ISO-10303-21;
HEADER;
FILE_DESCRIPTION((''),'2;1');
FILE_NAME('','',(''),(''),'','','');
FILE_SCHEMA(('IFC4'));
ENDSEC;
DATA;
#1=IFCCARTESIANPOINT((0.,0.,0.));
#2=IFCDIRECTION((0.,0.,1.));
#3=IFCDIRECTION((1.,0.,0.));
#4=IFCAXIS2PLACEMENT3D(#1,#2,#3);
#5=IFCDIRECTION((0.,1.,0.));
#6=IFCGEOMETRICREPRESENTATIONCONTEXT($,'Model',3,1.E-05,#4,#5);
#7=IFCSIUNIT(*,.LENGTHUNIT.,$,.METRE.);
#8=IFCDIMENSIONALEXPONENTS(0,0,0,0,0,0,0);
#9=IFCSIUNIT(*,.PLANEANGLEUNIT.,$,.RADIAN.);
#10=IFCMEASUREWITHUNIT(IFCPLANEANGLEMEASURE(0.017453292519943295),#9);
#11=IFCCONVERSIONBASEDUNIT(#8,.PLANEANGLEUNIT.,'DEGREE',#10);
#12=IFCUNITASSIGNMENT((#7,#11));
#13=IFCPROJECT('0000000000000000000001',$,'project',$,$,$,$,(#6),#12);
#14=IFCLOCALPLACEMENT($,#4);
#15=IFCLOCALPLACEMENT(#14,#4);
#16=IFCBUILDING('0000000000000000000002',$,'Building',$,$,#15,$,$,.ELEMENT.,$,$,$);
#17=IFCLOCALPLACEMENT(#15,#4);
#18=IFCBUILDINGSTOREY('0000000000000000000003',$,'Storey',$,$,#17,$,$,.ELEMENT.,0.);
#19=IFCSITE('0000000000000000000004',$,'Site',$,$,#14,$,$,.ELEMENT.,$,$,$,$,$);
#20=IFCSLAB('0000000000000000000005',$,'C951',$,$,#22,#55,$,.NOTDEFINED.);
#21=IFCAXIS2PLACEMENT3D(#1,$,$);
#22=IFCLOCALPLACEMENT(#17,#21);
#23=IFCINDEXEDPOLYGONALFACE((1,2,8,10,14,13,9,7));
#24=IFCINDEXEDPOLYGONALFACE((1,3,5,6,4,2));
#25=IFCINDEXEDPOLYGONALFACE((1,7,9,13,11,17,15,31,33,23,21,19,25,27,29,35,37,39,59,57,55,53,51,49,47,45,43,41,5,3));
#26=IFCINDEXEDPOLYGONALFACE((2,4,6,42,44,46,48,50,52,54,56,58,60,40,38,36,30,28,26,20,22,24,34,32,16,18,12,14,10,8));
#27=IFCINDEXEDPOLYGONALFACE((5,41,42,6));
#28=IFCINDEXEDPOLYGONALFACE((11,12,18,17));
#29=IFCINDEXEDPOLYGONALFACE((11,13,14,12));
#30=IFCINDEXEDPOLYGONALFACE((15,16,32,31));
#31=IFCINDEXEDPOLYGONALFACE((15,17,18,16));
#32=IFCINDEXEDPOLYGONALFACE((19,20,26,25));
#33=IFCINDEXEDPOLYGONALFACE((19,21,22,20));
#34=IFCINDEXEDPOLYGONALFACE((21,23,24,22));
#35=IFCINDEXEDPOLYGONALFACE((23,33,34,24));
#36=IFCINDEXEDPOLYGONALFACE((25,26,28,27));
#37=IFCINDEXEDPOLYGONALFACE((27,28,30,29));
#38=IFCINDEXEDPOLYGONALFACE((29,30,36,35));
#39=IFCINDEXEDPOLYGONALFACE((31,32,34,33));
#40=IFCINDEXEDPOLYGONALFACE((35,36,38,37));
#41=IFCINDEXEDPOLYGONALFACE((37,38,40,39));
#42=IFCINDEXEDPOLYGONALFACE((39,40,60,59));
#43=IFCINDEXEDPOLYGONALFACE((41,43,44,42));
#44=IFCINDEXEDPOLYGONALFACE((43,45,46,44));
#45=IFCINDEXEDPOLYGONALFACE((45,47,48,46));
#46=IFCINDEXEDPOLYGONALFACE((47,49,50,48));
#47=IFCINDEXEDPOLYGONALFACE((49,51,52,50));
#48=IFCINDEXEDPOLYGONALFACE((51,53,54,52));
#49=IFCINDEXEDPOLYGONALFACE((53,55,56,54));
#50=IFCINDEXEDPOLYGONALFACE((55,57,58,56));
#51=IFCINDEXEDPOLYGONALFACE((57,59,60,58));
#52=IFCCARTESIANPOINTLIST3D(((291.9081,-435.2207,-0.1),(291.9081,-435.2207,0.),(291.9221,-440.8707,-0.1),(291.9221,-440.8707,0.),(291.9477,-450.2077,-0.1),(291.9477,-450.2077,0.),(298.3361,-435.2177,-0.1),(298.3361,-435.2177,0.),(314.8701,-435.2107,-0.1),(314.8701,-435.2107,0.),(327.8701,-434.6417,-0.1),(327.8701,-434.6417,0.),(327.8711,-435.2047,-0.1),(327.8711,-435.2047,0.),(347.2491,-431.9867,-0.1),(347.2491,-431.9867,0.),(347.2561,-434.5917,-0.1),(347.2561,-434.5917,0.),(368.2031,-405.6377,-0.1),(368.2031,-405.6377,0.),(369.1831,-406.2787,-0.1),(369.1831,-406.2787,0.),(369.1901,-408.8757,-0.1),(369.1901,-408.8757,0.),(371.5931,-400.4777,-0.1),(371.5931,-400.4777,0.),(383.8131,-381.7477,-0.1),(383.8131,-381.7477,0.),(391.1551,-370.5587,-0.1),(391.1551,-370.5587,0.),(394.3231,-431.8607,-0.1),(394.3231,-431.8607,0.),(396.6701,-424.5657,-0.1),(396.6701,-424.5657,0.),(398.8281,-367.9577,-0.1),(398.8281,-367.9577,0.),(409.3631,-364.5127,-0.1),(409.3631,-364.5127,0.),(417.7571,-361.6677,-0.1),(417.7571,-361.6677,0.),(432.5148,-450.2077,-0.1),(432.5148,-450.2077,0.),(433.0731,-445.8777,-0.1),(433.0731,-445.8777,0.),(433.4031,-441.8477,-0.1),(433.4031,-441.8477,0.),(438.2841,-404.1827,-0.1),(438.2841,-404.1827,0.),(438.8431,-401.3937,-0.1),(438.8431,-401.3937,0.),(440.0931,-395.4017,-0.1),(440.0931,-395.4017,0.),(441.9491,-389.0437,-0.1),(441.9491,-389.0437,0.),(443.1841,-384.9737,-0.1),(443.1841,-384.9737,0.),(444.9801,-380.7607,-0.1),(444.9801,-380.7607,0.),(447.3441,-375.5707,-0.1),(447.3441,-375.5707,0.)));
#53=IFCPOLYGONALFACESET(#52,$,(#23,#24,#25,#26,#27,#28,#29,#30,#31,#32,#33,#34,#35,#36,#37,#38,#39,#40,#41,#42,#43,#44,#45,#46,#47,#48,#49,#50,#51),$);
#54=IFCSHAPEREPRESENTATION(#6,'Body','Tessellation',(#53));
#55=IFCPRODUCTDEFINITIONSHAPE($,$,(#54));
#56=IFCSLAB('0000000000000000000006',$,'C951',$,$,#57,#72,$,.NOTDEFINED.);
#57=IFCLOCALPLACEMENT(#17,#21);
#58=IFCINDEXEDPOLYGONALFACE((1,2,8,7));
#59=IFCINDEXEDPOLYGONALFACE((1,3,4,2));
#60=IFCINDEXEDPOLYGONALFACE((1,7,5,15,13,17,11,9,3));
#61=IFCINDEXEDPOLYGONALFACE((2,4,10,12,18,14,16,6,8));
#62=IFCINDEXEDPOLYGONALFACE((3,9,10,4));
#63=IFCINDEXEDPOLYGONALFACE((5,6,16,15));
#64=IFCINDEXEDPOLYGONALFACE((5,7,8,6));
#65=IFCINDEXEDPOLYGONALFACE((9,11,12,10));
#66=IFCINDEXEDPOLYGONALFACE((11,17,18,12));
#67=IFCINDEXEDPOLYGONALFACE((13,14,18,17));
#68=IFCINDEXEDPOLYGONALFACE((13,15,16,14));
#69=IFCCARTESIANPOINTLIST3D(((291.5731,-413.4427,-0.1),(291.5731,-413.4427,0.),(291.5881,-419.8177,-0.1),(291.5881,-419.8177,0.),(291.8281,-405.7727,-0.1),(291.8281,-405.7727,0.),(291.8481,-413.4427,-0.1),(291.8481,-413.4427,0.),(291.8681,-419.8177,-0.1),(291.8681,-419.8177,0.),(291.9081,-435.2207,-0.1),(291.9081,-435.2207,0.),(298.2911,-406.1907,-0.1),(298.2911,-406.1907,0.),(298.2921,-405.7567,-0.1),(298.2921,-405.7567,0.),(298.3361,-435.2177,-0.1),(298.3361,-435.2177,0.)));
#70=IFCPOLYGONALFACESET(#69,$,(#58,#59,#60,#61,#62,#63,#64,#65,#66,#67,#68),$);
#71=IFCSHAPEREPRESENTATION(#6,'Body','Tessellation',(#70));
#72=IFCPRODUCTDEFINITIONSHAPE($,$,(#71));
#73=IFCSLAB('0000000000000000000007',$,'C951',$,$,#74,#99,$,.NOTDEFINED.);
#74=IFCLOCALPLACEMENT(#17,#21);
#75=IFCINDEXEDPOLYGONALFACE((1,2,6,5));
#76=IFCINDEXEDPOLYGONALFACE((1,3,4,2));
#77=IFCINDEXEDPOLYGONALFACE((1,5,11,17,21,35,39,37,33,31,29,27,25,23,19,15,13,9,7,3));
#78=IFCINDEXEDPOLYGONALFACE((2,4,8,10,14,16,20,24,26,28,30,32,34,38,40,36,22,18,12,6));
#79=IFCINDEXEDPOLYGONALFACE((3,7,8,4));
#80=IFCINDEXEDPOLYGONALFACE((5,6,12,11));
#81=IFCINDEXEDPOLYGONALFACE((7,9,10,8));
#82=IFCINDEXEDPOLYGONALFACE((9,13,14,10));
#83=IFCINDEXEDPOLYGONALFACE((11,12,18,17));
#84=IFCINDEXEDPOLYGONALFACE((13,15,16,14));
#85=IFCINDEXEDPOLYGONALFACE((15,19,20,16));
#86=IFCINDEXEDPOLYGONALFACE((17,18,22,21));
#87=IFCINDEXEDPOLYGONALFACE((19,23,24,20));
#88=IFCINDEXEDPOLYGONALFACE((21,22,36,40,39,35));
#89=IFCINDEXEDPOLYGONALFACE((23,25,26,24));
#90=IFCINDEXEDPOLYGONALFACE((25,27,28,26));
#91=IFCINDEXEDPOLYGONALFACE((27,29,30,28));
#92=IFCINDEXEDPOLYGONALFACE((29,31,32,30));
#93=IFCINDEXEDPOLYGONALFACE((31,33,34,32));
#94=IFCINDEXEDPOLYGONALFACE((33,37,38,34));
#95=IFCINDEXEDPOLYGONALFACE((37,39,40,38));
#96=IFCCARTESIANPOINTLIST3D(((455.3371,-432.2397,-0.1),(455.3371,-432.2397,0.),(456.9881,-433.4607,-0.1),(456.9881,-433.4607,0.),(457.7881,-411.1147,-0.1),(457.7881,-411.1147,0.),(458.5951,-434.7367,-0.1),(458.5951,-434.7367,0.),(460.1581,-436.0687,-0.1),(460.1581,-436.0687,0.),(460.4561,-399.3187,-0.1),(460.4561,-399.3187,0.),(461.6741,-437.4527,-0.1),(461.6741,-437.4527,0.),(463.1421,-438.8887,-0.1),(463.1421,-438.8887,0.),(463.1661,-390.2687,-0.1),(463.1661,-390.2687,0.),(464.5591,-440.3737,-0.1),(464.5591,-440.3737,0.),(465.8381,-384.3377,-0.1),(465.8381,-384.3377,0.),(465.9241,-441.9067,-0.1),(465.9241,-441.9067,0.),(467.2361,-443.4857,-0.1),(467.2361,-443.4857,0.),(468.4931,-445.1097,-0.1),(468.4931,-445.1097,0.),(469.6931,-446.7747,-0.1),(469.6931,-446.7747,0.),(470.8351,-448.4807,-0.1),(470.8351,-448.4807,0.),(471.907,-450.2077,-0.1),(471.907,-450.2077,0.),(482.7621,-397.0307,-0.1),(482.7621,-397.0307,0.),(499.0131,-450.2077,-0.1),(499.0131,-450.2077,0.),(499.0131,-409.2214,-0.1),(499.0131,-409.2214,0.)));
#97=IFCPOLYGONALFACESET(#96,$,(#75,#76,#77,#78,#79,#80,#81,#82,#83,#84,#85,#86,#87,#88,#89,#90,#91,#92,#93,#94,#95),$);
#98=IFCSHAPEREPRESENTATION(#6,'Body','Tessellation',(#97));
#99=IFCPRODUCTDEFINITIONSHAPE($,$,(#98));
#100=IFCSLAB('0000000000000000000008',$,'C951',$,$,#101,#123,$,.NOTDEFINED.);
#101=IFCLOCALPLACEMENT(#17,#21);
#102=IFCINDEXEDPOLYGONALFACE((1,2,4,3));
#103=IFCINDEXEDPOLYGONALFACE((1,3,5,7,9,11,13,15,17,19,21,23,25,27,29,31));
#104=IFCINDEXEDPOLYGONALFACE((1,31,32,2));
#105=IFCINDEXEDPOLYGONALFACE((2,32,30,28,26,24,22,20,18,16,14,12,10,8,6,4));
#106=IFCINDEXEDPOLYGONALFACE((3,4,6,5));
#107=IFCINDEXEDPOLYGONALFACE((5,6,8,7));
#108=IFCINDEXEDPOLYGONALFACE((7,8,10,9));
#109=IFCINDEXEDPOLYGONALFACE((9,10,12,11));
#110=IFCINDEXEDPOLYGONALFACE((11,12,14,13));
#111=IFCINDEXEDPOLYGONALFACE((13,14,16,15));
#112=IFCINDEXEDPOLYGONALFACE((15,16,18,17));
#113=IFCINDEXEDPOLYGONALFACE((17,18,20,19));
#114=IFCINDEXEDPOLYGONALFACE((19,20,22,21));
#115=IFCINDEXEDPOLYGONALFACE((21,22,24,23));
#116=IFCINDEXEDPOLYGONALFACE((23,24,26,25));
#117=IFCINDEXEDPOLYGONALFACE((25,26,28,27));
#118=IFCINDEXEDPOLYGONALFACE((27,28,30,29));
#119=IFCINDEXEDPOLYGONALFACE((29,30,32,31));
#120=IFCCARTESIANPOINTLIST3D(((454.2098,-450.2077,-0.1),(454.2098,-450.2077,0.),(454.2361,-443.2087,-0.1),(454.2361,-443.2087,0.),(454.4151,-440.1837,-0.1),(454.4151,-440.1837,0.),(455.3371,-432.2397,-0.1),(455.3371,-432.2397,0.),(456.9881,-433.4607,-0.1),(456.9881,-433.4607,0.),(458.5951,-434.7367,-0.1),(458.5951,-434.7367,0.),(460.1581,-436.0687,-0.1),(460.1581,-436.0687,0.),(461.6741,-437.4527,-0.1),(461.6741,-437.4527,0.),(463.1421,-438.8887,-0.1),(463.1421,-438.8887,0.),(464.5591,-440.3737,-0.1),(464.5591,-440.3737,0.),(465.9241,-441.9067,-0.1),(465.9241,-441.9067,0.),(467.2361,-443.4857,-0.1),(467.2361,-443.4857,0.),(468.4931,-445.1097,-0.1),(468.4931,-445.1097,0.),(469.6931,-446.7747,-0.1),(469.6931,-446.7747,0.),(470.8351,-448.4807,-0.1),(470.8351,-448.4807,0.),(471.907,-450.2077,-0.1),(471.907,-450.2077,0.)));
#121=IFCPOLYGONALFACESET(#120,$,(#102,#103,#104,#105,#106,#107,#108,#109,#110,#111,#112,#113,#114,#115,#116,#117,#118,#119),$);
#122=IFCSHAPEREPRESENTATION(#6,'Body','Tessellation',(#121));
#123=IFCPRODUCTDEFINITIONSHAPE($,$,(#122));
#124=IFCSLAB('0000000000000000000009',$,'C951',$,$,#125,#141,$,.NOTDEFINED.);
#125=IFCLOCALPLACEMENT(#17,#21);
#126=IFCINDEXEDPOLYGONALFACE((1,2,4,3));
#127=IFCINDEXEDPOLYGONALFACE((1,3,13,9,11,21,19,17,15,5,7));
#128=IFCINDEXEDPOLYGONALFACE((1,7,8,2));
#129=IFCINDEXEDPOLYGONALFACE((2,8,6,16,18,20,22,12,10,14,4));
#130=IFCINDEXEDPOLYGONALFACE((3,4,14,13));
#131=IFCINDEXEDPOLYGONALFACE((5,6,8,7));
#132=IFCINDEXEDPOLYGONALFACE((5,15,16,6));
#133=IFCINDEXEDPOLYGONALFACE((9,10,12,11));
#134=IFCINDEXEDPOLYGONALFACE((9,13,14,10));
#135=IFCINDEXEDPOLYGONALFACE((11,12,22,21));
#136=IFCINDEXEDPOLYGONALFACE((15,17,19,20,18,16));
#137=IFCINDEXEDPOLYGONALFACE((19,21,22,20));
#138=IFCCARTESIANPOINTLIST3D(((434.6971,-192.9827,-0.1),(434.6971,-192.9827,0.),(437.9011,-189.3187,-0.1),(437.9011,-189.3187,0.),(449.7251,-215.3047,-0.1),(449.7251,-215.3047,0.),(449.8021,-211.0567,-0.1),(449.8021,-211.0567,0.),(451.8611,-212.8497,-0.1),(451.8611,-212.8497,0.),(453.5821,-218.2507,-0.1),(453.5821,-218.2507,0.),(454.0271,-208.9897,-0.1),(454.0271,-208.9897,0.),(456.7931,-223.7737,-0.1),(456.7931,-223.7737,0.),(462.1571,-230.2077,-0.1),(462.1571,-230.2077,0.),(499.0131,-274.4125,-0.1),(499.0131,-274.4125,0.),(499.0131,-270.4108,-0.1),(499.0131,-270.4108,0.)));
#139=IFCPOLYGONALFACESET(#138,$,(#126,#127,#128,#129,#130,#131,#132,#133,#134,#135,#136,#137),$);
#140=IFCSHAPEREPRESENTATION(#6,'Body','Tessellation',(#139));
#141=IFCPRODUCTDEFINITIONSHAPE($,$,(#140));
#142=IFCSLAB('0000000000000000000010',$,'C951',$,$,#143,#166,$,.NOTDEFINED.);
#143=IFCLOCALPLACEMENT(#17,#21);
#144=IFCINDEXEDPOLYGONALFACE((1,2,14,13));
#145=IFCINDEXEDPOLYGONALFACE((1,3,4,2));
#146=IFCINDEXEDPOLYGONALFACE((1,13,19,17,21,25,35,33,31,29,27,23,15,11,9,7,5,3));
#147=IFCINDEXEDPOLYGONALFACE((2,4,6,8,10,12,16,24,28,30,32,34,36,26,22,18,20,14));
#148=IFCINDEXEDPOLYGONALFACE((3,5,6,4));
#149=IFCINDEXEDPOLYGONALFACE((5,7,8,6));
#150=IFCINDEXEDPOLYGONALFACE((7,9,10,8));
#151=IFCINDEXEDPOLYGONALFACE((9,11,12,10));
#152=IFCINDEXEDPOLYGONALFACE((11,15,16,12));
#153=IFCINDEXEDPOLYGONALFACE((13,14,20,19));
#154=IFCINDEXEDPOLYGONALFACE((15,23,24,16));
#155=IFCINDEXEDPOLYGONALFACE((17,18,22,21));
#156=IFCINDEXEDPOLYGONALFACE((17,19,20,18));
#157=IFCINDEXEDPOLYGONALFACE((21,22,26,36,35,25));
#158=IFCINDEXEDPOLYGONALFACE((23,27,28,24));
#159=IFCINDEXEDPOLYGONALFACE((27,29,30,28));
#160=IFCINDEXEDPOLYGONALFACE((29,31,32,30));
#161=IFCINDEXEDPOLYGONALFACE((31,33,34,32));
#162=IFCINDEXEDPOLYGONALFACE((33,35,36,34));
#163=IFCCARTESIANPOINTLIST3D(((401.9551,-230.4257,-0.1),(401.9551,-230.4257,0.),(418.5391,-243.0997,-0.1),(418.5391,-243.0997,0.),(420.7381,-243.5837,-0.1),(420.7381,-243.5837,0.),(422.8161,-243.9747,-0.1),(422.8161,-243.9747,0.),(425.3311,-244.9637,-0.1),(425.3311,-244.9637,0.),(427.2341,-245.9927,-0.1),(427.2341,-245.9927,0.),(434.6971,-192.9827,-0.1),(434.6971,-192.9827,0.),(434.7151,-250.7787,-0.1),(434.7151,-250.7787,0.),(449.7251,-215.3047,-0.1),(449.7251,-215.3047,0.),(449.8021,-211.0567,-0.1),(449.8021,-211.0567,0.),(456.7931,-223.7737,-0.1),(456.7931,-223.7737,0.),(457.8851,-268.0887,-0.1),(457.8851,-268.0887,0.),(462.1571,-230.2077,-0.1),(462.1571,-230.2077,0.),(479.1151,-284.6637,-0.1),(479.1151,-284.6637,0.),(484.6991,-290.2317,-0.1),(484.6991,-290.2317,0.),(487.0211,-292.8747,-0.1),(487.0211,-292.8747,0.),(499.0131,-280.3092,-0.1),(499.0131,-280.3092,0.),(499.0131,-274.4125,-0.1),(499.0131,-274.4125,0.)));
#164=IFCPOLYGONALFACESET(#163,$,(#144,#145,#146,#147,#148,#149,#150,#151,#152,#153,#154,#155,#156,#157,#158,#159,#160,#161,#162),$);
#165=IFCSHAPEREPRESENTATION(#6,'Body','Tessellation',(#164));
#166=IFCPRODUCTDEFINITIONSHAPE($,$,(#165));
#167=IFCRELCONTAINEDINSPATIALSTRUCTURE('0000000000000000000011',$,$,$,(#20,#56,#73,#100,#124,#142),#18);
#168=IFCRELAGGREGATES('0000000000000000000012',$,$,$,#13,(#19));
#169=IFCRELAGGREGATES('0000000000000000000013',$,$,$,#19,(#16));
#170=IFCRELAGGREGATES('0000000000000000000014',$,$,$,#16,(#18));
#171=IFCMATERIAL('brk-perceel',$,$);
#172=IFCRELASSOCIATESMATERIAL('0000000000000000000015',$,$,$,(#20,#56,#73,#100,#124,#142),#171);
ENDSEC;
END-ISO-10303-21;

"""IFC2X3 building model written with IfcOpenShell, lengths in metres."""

from ifc_helpers import new_model, entity, si_unit, converted_unit, direction, frame, origin_with_axes, place, context, project, spatial, polyline, outline, extrude, material, element, save


model = new_model("IFC2X3")

# Units and contexts
model_context = context("Model", 3, precision=1e-05, world=origin_with_axes(), true_north=direction((0.0, 1.0, 0.0)))
ifc_project = project(units=[si_unit("LENGTHUNIT", "METRE"), converted_unit("PLANEANGLEUNIT", "DEGREE", entity("IfcPlaneAngleMeasure", 0.017453292519943295), si_unit("PLANEANGLEUNIT", "RADIAN"), dimensions=[0, 0, 0, 0, 0, 0, 0])], contexts=[model_context])

# Site, building, storey
site_placement = place(None, origin_with_axes())
site = spatial("IfcSite", under=ifc_project, at=site_placement, Name="Site", CompositionType="ELEMENT")
building_placement = place(site_placement, origin_with_axes())
building = spatial("IfcBuilding", under=site, at=building_placement, Name="Building", CompositionType="ELEMENT")
storey_placement = place(building_placement, origin_with_axes())
storey = spatial("IfcBuildingStorey", under=building, at=storey_placement, Name="Storey", CompositionType="ELEMENT", Elevation=0.0)

# Slabs
ifc_material = material(Name="brk-perceel")
slab_1_placement = place(storey_placement, frame((0.0, 0.0, -0.1), z_axis=(0.0, 0.0, 1.0), x_axis=(1.0, 0.0, 0.0)))
element("IfcSlab", 1, at=slab_1_placement, inside=storey, material=ifc_material, Name="C951", PredefinedType="NOTDEFINED", context=model_context, shape_type="SweptSolid", body=[
    extrude(outline(polyline([(291.9221, -440.8707), (291.9081, -435.2207), (298.3361, -435.2177), (314.8701, -435.2107), (327.8711, -435.2047), (327.8701, -434.6417), (347.2561, -434.5917), (347.2491, -431.9867), (394.3231, -431.8607), (396.6701, -424.5657), (369.1901, -408.8757), (369.1831, -406.2787), (368.2031, -405.6377), (371.5931, -400.4777), (383.8131, -381.7477), (391.1551, -370.5587), (398.8281, -367.9577), (409.3631, -364.5127), (417.7571, -361.6677), (447.3441, -375.5707), (444.9801, -380.7607), (443.1841, -384.9737), (441.9491, -389.0437), (440.0931, -395.4017), (438.8431, -401.3937), (438.2841, -404.1827), (433.4031, -441.8477), (433.0731, -445.8777), (432.5148, -450.2077), (291.9477, -450.2077), (291.9221, -440.8707)])), origin_with_axes(), (0.0, 0.0, 1.0), 0.1),
])
slab_2_placement = place(storey_placement, frame((0.0, 0.0, -0.1), z_axis=(0.0, 0.0, 1.0), x_axis=(1.0, 0.0, 0.0)))
element("IfcSlab", 2, at=slab_2_placement, inside=storey, material=ifc_material, Name="C951", PredefinedType="NOTDEFINED", context=model_context, shape_type="SweptSolid", body=[
    extrude(outline(polyline([(291.9081, -435.2207), (291.8681, -419.8177), (291.5881, -419.8177), (291.5731, -413.4427), (291.8481, -413.4427), (291.8281, -405.7727), (298.2921, -405.7567), (298.2911, -406.1907), (298.3361, -435.2177), (291.9081, -435.2207)])), origin_with_axes(), (0.0, 0.0, 1.0), 0.1),
])
slab_3_placement = place(storey_placement, frame((0.0, 0.0, -0.1), z_axis=(0.0, 0.0, 1.0), x_axis=(1.0, 0.0, 0.0)))
element("IfcSlab", 3, at=slab_3_placement, inside=storey, material=ifc_material, Name="C951", PredefinedType="NOTDEFINED", context=model_context, shape_type="SweptSolid", body=[
    extrude(outline(polyline([(470.8351, -448.4807), (469.6931, -446.7747), (468.4931, -445.1097), (467.2361, -443.4857), (465.9241, -441.9067), (464.5591, -440.3737), (463.1421, -438.8887), (461.6741, -437.4527), (460.1581, -436.0687), (458.5951, -434.7367), (456.9881, -433.4607), (455.3371, -432.2397), (457.7881, -411.1147), (460.4561, -399.3187), (463.1661, -390.2687), (465.8381, -384.3377), (482.7621, -397.0307), (499.0131, -409.2214), (499.0131, -450.2077), (471.907, -450.2077), (470.8351, -448.4807)])), origin_with_axes(), (0.0, 0.0, 1.0), 0.1),
])
slab_4_placement = place(storey_placement, frame((0.0, 0.0, -0.1), z_axis=(0.0, 0.0, 1.0), x_axis=(1.0, 0.0, 0.0)))
element("IfcSlab", 4, at=slab_4_placement, inside=storey, material=ifc_material, Name="C951", PredefinedType="NOTDEFINED", context=model_context, shape_type="SweptSolid", body=[
    extrude(outline(polyline([(454.2361, -443.2087), (454.4151, -440.1837), (455.3371, -432.2397), (456.9881, -433.4607), (458.5951, -434.7367), (460.1581, -436.0687), (461.6741, -437.4527), (463.1421, -438.8887), (464.5591, -440.3737), (465.9241, -441.9067), (467.2361, -443.4857), (468.4931, -445.1097), (469.6931, -446.7747), (470.8351, -448.4807), (471.907, -450.2077), (454.2098, -450.2077), (454.2361, -443.2087)])), origin_with_axes(), (0.0, 0.0, 1.0), 0.1),
])
slab_5_placement = place(storey_placement, frame((0.0, 0.0, -0.1), z_axis=(0.0, 0.0, 1.0), x_axis=(1.0, 0.0, 0.0)))
element("IfcSlab", 5, at=slab_5_placement, inside=storey, material=ifc_material, Name="C951", PredefinedType="NOTDEFINED", context=model_context, shape_type="SweptSolid", body=[
    extrude(outline(polyline([(462.1571, -230.2077), (456.7931, -223.7737), (449.7251, -215.3047), (449.8021, -211.0567), (434.6971, -192.9827), (437.9011, -189.3187), (454.0271, -208.9897), (451.8611, -212.8497), (453.5821, -218.2507), (499.0131, -270.4108), (499.0131, -274.4125), (462.1571, -230.2077)])), origin_with_axes(), (0.0, 0.0, 1.0), 0.1),
])
slab_6_placement = place(storey_placement, frame((0.0, 0.0, -0.1), z_axis=(0.0, 0.0, 1.0), x_axis=(1.0, 0.0, 0.0)))
element("IfcSlab", 6, at=slab_6_placement, inside=storey, material=ifc_material, Name="C951", PredefinedType="NOTDEFINED", context=model_context, shape_type="SweptSolid", body=[
    extrude(outline(polyline([(487.0211, -292.8747), (484.6991, -290.2317), (479.1151, -284.6637), (457.8851, -268.0887), (434.7151, -250.7787), (427.2341, -245.9927), (425.3311, -244.9637), (422.8161, -243.9747), (420.7381, -243.5837), (418.5391, -243.0997), (401.9551, -230.4257), (434.6971, -192.9827), (449.8021, -211.0567), (449.7251, -215.3047), (456.7931, -223.7737), (462.1571, -230.2077), (499.0131, -274.4125), (499.0131, -280.3092), (487.0211, -292.8747)])), origin_with_axes(), (0.0, 0.0, 1.0), 0.1),
])

save(model, "model.ifc")
